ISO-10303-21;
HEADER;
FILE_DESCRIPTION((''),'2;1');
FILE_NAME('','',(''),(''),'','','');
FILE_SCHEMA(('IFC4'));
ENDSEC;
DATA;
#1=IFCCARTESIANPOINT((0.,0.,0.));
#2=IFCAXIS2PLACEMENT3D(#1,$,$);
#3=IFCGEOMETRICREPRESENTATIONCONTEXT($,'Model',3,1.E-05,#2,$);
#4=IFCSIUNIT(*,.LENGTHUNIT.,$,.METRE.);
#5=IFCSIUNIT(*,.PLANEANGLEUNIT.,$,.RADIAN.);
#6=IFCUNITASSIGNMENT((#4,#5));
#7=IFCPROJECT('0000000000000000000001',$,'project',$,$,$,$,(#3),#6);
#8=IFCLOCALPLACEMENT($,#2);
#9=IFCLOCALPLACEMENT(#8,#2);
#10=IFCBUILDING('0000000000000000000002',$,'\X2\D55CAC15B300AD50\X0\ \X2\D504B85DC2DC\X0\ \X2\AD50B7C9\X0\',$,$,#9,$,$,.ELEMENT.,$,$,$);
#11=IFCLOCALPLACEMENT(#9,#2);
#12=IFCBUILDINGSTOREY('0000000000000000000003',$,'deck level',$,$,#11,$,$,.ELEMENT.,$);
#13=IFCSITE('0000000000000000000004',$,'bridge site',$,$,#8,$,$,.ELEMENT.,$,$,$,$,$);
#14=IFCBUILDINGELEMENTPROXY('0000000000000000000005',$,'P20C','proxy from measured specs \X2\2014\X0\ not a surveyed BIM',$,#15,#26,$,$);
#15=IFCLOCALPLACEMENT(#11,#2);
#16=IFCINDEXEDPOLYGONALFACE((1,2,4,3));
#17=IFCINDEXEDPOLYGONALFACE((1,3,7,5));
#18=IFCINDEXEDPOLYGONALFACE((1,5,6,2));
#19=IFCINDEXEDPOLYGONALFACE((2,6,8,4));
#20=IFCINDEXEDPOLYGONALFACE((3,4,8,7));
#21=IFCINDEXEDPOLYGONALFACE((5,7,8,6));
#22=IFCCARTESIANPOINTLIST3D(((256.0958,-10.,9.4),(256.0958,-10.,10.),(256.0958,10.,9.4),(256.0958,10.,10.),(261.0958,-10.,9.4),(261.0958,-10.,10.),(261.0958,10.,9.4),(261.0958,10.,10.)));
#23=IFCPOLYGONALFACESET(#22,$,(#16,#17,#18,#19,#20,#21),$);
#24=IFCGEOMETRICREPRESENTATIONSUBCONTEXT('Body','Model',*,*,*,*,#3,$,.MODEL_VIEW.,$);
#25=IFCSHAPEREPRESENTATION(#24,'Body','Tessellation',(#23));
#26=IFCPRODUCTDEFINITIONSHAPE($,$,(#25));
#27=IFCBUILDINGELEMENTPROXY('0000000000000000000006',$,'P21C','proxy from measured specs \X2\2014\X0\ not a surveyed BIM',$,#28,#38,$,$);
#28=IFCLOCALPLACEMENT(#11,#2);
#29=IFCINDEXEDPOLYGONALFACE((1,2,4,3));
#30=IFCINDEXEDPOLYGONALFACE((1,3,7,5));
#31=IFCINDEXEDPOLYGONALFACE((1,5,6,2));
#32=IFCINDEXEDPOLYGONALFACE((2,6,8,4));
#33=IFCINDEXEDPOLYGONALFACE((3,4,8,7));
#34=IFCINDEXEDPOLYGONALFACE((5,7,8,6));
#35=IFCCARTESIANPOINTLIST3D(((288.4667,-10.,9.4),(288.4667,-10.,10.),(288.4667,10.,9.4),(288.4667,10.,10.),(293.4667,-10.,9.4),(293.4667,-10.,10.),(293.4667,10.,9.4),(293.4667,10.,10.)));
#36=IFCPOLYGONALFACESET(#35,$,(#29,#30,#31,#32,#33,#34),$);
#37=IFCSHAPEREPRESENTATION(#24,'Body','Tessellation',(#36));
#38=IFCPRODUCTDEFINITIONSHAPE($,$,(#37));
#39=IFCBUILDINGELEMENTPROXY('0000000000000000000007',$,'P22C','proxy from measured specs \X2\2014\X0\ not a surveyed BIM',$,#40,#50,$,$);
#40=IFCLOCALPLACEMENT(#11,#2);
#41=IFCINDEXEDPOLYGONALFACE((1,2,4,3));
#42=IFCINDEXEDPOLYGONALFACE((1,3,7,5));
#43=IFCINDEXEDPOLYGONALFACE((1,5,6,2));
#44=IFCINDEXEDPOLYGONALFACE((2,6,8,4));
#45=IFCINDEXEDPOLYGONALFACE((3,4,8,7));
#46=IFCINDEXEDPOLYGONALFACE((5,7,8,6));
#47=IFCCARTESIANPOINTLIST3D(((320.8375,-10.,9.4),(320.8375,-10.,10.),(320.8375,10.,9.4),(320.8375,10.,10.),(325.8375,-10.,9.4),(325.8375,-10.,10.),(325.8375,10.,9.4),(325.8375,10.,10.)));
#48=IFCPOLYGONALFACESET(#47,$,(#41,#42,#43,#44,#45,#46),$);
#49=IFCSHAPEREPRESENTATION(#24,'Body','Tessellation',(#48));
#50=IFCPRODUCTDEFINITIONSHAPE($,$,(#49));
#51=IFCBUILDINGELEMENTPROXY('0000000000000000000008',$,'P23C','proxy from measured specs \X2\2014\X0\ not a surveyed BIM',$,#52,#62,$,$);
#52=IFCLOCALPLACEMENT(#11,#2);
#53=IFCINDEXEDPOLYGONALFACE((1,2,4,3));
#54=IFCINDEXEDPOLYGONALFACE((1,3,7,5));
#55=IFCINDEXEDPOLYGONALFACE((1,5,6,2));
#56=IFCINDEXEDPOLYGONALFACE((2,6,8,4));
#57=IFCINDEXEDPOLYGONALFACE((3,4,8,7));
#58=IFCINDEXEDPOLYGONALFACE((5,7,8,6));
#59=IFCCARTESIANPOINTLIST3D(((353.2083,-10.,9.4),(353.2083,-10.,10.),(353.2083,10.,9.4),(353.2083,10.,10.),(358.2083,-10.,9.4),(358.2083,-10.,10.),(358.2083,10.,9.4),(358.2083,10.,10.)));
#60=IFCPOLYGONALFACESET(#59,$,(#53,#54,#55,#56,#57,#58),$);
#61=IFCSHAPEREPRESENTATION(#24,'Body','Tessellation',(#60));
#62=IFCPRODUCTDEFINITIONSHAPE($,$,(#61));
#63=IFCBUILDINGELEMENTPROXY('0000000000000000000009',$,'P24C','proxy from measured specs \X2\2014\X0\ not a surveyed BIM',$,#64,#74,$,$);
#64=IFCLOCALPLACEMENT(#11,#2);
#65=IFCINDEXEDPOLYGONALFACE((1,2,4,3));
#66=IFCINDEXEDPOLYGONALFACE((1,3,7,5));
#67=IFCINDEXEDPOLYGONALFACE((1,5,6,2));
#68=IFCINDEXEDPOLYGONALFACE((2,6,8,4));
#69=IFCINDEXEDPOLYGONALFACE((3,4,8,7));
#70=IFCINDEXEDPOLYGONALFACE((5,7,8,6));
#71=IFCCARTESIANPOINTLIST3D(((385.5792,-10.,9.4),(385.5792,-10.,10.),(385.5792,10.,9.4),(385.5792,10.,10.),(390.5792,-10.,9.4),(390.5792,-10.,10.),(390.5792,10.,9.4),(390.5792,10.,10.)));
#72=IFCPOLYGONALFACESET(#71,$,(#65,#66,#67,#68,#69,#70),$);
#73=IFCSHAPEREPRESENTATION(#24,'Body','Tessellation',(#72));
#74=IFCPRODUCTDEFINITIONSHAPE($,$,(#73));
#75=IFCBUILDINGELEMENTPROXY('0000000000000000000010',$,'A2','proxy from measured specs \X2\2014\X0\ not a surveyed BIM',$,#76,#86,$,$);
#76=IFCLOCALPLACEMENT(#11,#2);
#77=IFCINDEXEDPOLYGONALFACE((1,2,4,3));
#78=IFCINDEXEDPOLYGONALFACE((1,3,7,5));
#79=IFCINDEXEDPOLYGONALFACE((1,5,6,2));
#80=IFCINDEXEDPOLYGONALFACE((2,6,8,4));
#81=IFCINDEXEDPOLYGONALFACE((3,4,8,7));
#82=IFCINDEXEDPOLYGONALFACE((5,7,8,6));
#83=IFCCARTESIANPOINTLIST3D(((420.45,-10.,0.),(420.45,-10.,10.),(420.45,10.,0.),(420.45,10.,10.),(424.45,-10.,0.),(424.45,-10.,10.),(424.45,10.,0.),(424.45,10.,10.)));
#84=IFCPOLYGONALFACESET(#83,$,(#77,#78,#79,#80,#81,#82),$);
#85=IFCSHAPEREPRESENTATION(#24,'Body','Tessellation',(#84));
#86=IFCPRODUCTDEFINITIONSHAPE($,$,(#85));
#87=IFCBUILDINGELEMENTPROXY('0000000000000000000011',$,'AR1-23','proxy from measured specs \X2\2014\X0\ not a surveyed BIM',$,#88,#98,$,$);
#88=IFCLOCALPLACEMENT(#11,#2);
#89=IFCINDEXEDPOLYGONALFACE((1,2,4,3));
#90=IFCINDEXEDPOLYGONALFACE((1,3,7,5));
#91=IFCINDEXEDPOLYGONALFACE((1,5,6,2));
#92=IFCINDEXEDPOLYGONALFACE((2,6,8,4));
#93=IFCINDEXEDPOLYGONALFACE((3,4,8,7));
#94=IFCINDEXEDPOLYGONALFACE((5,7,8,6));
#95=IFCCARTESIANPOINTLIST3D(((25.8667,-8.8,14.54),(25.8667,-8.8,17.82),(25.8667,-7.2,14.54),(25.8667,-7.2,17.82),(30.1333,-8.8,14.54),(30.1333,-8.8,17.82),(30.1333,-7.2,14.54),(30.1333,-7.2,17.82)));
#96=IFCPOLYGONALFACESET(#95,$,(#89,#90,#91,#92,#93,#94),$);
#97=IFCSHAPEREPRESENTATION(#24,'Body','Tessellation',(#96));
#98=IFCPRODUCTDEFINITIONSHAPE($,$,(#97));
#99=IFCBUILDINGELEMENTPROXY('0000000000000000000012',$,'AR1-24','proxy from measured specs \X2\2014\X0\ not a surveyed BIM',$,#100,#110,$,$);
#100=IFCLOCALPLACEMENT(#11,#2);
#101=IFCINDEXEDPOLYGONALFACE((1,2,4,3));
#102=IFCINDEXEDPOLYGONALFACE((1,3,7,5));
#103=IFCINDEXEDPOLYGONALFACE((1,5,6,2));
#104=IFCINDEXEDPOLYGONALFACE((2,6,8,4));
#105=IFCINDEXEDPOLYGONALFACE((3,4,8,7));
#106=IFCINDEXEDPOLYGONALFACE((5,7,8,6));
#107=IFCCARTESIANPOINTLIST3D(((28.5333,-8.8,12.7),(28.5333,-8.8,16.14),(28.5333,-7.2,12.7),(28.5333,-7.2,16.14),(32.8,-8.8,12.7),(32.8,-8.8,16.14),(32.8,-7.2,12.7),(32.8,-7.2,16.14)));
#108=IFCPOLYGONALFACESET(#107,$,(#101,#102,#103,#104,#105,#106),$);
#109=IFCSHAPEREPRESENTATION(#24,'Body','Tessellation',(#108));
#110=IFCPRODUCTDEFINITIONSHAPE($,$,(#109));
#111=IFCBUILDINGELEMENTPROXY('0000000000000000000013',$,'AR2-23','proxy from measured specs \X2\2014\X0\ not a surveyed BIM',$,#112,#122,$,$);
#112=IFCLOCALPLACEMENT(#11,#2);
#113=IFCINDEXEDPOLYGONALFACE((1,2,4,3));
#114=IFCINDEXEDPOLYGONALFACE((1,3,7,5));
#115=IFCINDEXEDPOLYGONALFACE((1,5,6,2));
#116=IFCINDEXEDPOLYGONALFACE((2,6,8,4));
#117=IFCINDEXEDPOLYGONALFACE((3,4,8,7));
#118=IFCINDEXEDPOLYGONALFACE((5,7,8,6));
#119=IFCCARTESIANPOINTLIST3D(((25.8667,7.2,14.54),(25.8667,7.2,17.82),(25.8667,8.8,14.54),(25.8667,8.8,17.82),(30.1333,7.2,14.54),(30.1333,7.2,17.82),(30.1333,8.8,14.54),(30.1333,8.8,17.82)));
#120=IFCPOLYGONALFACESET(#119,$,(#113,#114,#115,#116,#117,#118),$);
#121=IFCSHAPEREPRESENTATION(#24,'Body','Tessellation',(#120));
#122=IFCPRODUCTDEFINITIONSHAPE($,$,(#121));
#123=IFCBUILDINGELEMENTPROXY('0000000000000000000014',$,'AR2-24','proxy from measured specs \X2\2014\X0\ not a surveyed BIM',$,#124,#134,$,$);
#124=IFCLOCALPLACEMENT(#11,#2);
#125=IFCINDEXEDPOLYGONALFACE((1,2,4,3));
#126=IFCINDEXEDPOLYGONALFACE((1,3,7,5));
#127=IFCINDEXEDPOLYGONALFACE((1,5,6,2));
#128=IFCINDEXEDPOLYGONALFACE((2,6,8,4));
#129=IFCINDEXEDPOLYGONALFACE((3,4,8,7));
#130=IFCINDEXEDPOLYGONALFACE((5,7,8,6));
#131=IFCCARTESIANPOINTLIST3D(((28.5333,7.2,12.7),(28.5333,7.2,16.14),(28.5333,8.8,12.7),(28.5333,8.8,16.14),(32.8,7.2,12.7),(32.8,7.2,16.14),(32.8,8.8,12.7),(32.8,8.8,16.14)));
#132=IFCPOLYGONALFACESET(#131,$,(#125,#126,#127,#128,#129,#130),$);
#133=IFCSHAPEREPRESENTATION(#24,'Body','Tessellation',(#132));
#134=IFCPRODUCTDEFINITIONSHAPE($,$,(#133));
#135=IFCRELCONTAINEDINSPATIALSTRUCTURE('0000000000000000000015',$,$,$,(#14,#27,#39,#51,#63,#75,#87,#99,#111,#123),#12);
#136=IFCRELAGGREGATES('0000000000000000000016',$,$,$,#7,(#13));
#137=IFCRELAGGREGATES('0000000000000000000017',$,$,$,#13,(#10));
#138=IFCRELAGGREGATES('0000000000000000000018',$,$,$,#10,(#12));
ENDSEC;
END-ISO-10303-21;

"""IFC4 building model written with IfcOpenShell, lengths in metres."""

from ifc_helpers import new_model, si_unit, frame, origin, origin_2d, place, context, subcontext, project, spatial, rectangle, extrude, element, save


model = new_model("IFC4")

# Units and contexts
model_context = context("Model", 3, precision=1e-05, world=origin())
body_context = subcontext(model_context, "Body", "Model", "MODEL_VIEW")
ifc_project = project(units=[si_unit("LENGTHUNIT", "METRE"), si_unit("PLANEANGLEUNIT", "RADIAN")], contexts=[model_context])

# Site, building, storey
site_placement = place(None, origin())
site = spatial("IfcSite", under=ifc_project, at=site_placement, Name="bridge site", CompositionType="ELEMENT")
building_placement = place(site_placement, origin())
building = spatial("IfcBuilding", under=site, at=building_placement, Name="한강대교 프록시 교량", CompositionType="ELEMENT")
storey_placement = place(building_placement, origin())
storey = spatial("IfcBuildingStorey", under=building, at=storey_placement, Name="deck level", CompositionType="ELEMENT")

# Building element proxies
for number, where, name in (
    (1, (258.5958, 0.0, 9.4), "P20C"),
    (2, (290.9667, 0.0, 9.4), "P21C"),
    (3, (323.3375, 0.0, 9.4), "P22C"),
    (4, (355.7083, 0.0, 9.4), "P23C"),
    (5, (388.0792, 0.0, 9.4), "P24C"),
):
    element("IfcBuildingElementProxy", number, at=place(storey_placement, frame(where)), inside=storey, Name=name, Description="proxy from measured specs — not a surveyed BIM", context=body_context, shape_type="SweptSolid", body=[
        extrude(rectangle(XDim=5.0, YDim=20.0, at=origin_2d()), origin(), (0.0, 0.0, 1.0), 0.6),
    ])
proxy_1_placement = place(storey_placement, frame((422.45, 0.0, 0.0)))
element("IfcBuildingElementProxy", 6, at=proxy_1_placement, inside=storey, Name="A2", Description="proxy from measured specs — not a surveyed BIM", context=body_context, shape_type="SweptSolid", body=[
    extrude(rectangle(XDim=4.0, YDim=20.0, at=origin_2d()), origin(), (0.0, 0.0, 1.0), 10.0),
])
proxy_2_placement = place(storey_placement, frame((28.0, -8.0, 14.54)))
element("IfcBuildingElementProxy", 7, at=proxy_2_placement, inside=storey, Name="AR1-23", Description="proxy from measured specs — not a surveyed BIM", context=body_context, shape_type="SweptSolid", body=[
    extrude(rectangle(XDim=4.2667, YDim=1.6, at=origin_2d()), origin(), (0.0, 0.0, 1.0), 3.28),
])
proxy_3_placement = place(storey_placement, frame((30.6667, -8.0, 12.7)))
element("IfcBuildingElementProxy", 8, at=proxy_3_placement, inside=storey, Name="AR1-24", Description="proxy from measured specs — not a surveyed BIM", context=body_context, shape_type="SweptSolid", body=[
    extrude(rectangle(XDim=4.2667, YDim=1.6, at=origin_2d()), origin(), (0.0, 0.0, 1.0), 3.44),
])
proxy_4_placement = place(storey_placement, frame((28.0, 8.0, 14.54)))
element("IfcBuildingElementProxy", 9, at=proxy_4_placement, inside=storey, Name="AR2-23", Description="proxy from measured specs — not a surveyed BIM", context=body_context, shape_type="SweptSolid", body=[
    extrude(rectangle(XDim=4.2667, YDim=1.6, at=origin_2d()), origin(), (0.0, 0.0, 1.0), 3.28),
])
proxy_5_placement = place(storey_placement, frame((30.6667, 8.0, 12.7)))
element("IfcBuildingElementProxy", 10, at=proxy_5_placement, inside=storey, Name="AR2-24", Description="proxy from measured specs — not a surveyed BIM", context=body_context, shape_type="SweptSolid", body=[
    extrude(rectangle(XDim=4.2667, YDim=1.6, at=origin_2d()), origin(), (0.0, 0.0, 1.0), 3.44),
])

save(model, "model.ifc")
